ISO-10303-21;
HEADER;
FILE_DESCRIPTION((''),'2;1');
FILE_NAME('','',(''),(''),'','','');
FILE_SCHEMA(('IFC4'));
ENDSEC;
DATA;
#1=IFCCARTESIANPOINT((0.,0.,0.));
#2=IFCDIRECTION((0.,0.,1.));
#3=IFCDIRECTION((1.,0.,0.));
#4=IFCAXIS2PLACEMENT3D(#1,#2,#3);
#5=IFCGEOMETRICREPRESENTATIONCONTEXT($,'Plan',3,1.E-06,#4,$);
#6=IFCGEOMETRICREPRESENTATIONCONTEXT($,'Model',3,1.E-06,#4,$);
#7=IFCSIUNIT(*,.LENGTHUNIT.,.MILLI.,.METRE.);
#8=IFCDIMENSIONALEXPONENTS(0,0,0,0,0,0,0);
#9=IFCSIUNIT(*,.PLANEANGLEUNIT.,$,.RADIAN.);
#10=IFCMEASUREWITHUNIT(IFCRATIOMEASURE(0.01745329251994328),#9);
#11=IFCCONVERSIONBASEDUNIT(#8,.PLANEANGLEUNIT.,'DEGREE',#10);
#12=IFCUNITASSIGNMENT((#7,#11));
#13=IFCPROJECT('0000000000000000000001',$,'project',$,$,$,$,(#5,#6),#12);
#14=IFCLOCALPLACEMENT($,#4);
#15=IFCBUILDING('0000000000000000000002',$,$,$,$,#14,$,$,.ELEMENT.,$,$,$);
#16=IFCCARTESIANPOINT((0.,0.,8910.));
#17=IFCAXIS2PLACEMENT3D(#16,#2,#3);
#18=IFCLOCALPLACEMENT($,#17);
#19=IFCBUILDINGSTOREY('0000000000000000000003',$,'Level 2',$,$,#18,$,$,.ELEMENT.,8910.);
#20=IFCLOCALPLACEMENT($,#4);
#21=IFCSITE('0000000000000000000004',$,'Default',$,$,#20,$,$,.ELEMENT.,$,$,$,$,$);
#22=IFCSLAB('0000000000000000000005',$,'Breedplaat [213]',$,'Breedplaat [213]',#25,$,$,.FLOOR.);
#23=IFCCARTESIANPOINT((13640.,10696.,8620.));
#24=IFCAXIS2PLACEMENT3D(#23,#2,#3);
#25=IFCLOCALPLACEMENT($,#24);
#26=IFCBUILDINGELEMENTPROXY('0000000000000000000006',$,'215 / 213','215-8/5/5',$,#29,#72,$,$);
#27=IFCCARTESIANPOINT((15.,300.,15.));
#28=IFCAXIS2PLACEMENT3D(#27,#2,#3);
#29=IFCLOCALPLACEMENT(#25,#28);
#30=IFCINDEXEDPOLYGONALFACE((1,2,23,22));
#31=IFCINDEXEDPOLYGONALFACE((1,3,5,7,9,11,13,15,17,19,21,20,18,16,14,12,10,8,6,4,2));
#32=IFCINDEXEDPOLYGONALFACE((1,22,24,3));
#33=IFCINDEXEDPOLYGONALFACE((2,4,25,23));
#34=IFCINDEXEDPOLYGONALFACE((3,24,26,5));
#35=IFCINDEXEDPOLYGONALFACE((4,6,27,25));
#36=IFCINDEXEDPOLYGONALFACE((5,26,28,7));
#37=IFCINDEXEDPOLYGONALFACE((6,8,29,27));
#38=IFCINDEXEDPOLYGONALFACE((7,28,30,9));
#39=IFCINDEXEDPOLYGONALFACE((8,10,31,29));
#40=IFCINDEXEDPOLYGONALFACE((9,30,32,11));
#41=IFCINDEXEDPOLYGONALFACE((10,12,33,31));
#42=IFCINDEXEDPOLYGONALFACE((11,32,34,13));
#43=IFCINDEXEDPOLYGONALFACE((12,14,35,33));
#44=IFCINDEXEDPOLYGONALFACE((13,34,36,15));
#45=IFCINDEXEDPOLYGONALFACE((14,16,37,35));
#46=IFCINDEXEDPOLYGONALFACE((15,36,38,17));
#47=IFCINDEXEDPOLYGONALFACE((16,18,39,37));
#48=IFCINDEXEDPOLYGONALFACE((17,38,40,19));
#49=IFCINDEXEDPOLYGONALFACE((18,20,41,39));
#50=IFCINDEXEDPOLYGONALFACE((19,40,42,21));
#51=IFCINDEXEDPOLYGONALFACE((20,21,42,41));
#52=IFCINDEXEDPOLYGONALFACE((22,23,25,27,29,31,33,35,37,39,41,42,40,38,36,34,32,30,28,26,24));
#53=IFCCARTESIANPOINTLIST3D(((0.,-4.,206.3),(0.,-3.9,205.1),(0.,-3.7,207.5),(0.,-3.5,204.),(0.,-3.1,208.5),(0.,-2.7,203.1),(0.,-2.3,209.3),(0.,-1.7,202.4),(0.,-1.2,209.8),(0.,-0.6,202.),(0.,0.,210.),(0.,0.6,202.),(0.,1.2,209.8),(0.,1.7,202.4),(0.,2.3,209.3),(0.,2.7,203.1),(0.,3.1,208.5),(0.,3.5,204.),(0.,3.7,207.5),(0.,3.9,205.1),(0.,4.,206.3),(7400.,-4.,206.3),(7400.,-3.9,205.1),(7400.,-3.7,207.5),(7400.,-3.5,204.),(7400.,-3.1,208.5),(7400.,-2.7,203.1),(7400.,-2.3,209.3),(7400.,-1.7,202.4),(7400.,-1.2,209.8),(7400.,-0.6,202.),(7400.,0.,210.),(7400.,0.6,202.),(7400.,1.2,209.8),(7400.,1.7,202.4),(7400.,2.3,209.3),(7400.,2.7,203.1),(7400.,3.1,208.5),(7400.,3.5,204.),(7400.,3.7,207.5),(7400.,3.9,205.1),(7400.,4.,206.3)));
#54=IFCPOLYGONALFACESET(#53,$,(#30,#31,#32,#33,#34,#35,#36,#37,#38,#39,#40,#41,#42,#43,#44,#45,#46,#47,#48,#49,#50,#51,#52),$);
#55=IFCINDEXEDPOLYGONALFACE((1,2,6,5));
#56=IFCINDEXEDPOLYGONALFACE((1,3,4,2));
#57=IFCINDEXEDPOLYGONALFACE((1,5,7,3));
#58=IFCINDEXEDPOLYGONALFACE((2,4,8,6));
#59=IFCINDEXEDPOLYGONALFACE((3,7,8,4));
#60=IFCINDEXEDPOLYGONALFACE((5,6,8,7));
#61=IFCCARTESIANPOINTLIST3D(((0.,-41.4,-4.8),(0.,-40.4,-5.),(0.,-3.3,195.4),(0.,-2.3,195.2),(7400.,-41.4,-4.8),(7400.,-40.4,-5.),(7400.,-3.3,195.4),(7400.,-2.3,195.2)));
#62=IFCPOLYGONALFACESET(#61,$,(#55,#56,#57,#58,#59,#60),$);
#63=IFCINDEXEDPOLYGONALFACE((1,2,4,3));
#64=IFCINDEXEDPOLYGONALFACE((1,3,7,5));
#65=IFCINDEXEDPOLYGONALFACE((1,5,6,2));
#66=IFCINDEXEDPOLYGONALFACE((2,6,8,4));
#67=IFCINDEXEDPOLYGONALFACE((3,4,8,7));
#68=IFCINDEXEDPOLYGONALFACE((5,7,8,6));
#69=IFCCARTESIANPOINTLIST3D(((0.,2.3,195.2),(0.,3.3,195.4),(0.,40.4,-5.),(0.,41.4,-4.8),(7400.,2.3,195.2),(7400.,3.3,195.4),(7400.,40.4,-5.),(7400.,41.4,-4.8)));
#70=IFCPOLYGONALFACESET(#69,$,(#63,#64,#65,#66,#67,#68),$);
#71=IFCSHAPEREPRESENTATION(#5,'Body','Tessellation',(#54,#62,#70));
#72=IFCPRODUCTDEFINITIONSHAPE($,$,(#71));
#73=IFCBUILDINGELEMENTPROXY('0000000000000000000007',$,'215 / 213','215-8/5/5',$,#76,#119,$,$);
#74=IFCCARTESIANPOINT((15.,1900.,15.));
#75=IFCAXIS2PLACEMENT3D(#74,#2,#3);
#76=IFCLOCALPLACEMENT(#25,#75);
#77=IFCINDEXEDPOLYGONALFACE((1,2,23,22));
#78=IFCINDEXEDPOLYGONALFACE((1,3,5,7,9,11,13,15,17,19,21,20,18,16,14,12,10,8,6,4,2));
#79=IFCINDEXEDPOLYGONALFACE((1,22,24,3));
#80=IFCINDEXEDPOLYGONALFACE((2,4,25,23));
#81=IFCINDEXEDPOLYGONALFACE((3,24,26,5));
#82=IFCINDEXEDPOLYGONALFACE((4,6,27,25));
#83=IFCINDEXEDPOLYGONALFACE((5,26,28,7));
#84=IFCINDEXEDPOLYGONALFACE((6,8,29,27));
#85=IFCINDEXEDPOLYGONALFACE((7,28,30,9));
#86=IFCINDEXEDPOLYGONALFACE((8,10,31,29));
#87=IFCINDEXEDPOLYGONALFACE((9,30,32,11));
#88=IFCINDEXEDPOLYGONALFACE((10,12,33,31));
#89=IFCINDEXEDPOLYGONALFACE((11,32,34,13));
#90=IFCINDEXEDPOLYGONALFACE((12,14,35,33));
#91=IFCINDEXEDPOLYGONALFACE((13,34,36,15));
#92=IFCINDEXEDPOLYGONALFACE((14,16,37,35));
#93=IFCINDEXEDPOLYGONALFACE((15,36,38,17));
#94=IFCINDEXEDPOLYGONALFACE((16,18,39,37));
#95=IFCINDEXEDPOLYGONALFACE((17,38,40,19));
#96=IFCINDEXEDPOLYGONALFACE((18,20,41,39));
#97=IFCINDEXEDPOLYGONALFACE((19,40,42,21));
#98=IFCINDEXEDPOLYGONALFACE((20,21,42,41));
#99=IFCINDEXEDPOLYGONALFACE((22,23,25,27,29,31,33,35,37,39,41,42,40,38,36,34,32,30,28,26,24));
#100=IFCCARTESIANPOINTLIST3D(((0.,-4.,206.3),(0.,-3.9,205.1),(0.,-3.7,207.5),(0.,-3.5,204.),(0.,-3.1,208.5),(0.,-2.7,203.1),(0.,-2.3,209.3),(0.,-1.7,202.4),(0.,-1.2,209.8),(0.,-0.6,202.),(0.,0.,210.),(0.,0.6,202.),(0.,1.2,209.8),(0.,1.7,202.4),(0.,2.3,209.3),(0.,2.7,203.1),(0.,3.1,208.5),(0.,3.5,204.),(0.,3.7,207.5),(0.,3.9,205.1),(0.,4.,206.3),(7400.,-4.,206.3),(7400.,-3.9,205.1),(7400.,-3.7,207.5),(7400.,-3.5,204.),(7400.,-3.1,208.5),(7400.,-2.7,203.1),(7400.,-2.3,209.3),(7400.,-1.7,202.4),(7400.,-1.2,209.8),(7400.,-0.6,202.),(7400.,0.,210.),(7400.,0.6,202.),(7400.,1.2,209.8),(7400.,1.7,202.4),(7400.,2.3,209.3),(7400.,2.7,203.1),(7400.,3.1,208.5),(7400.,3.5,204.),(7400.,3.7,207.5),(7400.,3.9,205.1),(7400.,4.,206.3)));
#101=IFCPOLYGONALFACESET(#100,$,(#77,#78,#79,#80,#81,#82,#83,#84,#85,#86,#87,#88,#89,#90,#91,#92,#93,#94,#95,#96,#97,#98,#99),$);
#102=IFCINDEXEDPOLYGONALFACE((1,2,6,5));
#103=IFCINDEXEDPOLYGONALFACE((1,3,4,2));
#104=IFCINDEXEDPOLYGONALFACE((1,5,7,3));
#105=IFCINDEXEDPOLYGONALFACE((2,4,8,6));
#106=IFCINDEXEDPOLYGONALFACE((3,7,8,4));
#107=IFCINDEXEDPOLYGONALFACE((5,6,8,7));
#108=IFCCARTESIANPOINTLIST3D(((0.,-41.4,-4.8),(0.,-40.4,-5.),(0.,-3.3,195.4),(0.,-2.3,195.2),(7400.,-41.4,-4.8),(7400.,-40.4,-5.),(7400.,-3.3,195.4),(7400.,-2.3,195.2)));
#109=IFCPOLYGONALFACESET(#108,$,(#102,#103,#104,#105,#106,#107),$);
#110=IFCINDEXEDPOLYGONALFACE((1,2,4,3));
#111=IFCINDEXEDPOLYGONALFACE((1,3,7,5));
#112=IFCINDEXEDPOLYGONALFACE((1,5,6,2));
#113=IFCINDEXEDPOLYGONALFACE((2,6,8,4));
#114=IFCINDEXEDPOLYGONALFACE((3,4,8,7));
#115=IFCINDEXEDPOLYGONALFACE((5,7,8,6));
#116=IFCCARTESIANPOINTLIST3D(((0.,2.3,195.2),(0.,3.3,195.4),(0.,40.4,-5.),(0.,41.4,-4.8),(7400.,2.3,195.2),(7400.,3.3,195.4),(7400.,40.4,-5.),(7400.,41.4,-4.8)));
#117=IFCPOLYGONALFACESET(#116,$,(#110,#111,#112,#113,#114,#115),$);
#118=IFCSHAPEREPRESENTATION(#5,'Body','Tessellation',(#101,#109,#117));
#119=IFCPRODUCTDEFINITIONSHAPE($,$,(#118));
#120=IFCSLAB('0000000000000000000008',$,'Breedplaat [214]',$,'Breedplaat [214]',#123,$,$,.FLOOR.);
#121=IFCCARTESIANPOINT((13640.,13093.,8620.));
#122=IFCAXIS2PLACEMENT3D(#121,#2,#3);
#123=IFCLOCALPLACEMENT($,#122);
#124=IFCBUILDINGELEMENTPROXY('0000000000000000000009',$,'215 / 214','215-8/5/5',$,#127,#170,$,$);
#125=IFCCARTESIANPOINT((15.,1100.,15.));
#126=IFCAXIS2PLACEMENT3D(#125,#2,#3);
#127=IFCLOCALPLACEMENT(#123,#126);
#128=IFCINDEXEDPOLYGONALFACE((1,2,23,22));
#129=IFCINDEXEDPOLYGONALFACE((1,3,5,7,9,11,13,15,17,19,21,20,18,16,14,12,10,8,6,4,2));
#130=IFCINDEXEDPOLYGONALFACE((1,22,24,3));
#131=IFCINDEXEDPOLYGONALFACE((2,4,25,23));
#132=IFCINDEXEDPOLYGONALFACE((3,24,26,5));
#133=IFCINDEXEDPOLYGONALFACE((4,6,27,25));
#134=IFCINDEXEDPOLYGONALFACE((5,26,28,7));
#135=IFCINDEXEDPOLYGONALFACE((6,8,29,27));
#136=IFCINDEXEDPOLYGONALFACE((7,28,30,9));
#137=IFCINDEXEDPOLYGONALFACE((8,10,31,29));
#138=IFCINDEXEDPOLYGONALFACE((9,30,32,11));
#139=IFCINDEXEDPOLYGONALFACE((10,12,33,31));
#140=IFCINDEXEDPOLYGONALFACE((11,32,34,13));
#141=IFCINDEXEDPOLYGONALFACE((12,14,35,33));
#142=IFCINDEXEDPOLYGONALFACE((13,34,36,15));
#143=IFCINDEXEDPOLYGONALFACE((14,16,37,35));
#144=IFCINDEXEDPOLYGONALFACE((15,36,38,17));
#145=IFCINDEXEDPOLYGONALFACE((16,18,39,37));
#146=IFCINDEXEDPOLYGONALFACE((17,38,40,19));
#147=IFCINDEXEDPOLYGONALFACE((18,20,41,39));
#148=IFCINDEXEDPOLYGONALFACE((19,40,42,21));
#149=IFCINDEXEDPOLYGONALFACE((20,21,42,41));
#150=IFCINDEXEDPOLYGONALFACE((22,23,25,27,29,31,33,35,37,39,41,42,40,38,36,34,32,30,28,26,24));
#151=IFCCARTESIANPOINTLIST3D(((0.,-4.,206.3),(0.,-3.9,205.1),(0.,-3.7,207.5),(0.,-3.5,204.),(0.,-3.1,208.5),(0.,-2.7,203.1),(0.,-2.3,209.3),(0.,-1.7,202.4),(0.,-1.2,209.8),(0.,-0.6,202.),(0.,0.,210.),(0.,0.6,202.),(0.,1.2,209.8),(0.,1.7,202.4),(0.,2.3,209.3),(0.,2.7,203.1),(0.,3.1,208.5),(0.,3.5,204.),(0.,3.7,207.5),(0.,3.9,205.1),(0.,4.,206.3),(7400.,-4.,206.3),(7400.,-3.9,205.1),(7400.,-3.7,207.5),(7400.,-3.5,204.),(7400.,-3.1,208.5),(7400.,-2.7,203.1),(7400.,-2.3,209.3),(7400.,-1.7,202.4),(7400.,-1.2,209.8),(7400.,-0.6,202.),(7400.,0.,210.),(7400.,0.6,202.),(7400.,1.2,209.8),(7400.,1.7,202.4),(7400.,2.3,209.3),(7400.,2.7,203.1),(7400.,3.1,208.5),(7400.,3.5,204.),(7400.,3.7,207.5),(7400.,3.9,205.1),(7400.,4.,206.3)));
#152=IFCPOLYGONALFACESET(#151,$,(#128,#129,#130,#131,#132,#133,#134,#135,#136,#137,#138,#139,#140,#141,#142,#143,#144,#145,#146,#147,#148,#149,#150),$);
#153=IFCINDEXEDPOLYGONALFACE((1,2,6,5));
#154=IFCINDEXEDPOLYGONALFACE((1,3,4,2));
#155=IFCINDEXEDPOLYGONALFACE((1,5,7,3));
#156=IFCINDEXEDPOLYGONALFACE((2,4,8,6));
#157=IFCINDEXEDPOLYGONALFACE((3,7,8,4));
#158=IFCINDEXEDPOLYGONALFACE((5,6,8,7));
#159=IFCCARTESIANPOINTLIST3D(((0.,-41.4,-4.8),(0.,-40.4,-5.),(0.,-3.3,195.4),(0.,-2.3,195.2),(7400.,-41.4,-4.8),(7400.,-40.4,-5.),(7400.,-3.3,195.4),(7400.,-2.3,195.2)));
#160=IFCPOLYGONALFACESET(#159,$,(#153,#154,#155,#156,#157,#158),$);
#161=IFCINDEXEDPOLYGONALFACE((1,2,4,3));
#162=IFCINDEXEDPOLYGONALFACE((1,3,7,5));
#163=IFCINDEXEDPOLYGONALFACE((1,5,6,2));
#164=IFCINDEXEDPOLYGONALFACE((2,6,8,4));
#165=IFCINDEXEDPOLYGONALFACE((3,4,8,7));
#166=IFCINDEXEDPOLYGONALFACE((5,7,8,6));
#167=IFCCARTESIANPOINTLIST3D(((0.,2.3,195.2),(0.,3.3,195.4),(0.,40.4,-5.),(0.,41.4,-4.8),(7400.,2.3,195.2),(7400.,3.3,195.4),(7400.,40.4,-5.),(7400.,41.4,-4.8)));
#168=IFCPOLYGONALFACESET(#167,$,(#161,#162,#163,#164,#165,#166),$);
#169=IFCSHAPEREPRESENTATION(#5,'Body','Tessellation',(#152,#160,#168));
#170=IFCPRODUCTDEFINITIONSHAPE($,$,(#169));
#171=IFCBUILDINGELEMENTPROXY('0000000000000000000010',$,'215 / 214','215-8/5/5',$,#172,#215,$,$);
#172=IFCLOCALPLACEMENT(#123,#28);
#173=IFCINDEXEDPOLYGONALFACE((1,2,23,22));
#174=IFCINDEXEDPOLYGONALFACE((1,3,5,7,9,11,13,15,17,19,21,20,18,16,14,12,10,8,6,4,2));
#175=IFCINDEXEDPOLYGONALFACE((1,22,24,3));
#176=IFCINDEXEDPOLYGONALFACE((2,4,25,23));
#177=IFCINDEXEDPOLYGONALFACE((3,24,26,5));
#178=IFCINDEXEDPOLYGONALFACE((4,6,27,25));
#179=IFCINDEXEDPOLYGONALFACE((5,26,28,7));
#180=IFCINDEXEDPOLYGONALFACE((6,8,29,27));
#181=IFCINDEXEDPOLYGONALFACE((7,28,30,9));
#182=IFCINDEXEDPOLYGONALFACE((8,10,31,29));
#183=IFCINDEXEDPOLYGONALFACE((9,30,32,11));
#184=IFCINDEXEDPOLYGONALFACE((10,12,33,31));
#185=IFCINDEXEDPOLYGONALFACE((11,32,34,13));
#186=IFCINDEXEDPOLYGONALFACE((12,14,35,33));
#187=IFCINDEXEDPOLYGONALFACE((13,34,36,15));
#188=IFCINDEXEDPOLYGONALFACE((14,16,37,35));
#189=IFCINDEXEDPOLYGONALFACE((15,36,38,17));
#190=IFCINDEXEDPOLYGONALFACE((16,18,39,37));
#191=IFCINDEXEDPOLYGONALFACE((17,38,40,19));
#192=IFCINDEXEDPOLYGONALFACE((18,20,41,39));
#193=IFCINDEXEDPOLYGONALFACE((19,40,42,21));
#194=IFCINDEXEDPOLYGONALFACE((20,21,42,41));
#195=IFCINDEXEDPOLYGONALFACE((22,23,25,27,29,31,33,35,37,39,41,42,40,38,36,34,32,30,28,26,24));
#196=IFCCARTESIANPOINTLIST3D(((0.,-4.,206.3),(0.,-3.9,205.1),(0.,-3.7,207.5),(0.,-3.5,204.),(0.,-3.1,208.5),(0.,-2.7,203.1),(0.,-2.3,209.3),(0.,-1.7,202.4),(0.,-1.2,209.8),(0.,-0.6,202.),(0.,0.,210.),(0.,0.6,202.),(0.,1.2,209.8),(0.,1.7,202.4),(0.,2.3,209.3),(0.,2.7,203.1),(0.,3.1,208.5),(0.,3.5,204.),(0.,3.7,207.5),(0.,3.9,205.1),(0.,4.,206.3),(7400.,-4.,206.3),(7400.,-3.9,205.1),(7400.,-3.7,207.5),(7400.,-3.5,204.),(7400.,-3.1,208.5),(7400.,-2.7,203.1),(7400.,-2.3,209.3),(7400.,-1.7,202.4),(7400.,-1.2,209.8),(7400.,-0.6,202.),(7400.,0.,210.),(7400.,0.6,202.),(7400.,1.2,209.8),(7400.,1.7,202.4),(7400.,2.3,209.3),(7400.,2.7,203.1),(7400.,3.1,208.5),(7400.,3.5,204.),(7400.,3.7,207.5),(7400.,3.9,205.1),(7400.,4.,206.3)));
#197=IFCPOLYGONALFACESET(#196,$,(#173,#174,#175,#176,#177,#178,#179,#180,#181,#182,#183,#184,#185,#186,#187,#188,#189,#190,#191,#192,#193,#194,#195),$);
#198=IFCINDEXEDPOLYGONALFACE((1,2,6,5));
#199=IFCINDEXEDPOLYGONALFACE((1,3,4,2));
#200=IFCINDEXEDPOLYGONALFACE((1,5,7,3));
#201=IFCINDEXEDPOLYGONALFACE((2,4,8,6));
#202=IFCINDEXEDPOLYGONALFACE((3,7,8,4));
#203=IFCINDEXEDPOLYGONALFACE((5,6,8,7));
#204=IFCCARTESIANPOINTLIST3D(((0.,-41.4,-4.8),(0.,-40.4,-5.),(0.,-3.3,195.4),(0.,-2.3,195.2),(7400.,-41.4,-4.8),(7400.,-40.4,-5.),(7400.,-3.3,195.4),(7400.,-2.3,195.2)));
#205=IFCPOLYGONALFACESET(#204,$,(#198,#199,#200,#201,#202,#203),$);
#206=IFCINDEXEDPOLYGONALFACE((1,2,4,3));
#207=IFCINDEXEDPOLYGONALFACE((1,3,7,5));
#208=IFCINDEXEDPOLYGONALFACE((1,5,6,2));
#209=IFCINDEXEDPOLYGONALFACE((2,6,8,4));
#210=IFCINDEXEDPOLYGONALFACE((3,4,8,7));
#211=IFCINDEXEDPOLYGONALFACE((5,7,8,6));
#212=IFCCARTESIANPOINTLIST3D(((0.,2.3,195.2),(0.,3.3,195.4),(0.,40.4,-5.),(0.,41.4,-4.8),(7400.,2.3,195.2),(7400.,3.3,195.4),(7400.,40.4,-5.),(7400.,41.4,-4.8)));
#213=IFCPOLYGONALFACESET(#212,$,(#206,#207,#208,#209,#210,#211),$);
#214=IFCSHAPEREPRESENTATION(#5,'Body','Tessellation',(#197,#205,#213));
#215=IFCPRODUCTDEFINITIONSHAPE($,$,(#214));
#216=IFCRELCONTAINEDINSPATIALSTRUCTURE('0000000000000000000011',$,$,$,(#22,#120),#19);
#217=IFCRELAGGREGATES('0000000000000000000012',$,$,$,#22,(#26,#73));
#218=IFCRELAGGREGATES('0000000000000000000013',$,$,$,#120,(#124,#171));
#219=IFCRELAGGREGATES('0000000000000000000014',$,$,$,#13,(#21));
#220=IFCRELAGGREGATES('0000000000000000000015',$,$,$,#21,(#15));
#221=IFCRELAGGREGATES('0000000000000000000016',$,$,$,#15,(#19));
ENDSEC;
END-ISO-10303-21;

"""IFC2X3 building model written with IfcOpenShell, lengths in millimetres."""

from ifc_helpers import new_model, entity, si_unit, converted_unit, frame, origin_with_axes, origin_2d_with_axis, place, context, project, spatial, rectangle, circle, extrude, element, aggregate, save


model = new_model("IFC2X3")

# Units and contexts
plan_context = context("Plan", 3, precision=1e-06, world=origin_with_axes())
model_context = context("Model", 3, precision=1e-06, world=origin_with_axes())
ifc_project = project(units=[si_unit("LENGTHUNIT", "METRE", prefix="MILLI"), converted_unit("PLANEANGLEUNIT", "DEGREE", entity("IfcRatioMeasure", 0.01745329251994328), si_unit("PLANEANGLEUNIT", "RADIAN"), dimensions=[0, 0, 0, 0, 0, 0, 0])], contexts=[plan_context, model_context])

# Site, building, storey
site_placement = place(None, origin_with_axes())
site = spatial("IfcSite", under=ifc_project, at=site_placement, Name="Default", CompositionType="ELEMENT")
building_placement = place(None, origin_with_axes())
building = spatial("IfcBuilding", under=site, at=building_placement, CompositionType="ELEMENT")
storey_placement = place(None, frame((0.0, 0.0, 8910.0), z_axis=(0.0, 0.0, 1.0), x_axis=(1.0, 0.0, 0.0)))
storey = spatial("IfcBuildingStorey", under=building, at=storey_placement, Name="Level 2", CompositionType="ELEMENT", Elevation=8910.0)

# Slabs, building element proxies
slab_1_placement = place(None, frame((13640.0, 10696.0, 8620.0), z_axis=(0.0, 0.0, 1.0), x_axis=(1.0, 0.0, 0.0)))
slab_1 = element("IfcSlab", 1, at=slab_1_placement, inside=storey, Name="Breedplaat [213]", ObjectType="Breedplaat [213]", PredefinedType="FLOOR")
proxy_1_placement = place(slab_1_placement, frame((15.0, 300.0, 15.0), z_axis=(0.0, 0.0, 1.0), x_axis=(1.0, 0.0, 0.0)))
proxy_1 = element("IfcBuildingElementProxy", 2, at=proxy_1_placement, Name="215 / 213", Description="215-8/5/5", context=plan_context, shape_type="SweptSolid", body=[
    extrude(circle(Radius=4.0, at=origin_2d_with_axis()), frame((0.0, 0.0, 206.0), z_axis=(1.0, 0.0, 0.0), x_axis=(0.0, 0.0, 1.0)), (0.0, 0.0, 1.0), 7400.0),
    extrude(rectangle(XDim=203.8, YDim=1.0, at=origin_2d_with_axis()), frame((0.0, -21.9, 95.2), z_axis=(1.0, 0.0, 0.0), x_axis=(0.0, 0.187112, 0.982339)), (0.0, 0.0, 1.0), 7400.0),
    extrude(rectangle(XDim=203.8, YDim=1.0, at=origin_2d_with_axis()), frame((0.0, 21.9, 95.2), z_axis=(1.0, 0.0, 0.0), x_axis=(0.0, -0.187112, 0.982339)), (0.0, 0.0, 1.0), 7400.0),
])
proxy_2_placement = place(slab_1_placement, frame((15.0, 1900.0, 15.0), z_axis=(0.0, 0.0, 1.0), x_axis=(1.0, 0.0, 0.0)))
proxy_2 = element("IfcBuildingElementProxy", 3, at=proxy_2_placement, Name="215 / 213", Description="215-8/5/5", context=plan_context, shape_type="SweptSolid", body=[
    extrude(circle(Radius=4.0, at=origin_2d_with_axis()), frame((0.0, 0.0, 206.0), z_axis=(1.0, 0.0, 0.0), x_axis=(0.0, 0.0, 1.0)), (0.0, 0.0, 1.0), 7400.0),
    extrude(rectangle(XDim=203.8, YDim=1.0, at=origin_2d_with_axis()), frame((0.0, -21.9, 95.2), z_axis=(1.0, 0.0, 0.0), x_axis=(0.0, 0.187112, 0.982339)), (0.0, 0.0, 1.0), 7400.0),
    extrude(rectangle(XDim=203.8, YDim=1.0, at=origin_2d_with_axis()), frame((0.0, 21.9, 95.2), z_axis=(1.0, 0.0, 0.0), x_axis=(0.0, -0.187112, 0.982339)), (0.0, 0.0, 1.0), 7400.0),
])
aggregate(slab_1, [proxy_1, proxy_2])
slab_2_placement = place(None, frame((13640.0, 13093.0, 8620.0), z_axis=(0.0, 0.0, 1.0), x_axis=(1.0, 0.0, 0.0)))
slab_2 = element("IfcSlab", 4, at=slab_2_placement, inside=storey, Name="Breedplaat [214]", ObjectType="Breedplaat [214]", PredefinedType="FLOOR")
proxy_3_placement = place(slab_2_placement, frame((15.0, 1100.0, 15.0), z_axis=(0.0, 0.0, 1.0), x_axis=(1.0, 0.0, 0.0)))
proxy_3 = element("IfcBuildingElementProxy", 5, at=proxy_3_placement, Name="215 / 214", Description="215-8/5/5", context=plan_context, shape_type="SweptSolid", body=[
    extrude(circle(Radius=4.0, at=origin_2d_with_axis()), frame((0.0, 0.0, 206.0), z_axis=(1.0, 0.0, 0.0), x_axis=(0.0, 0.0, 1.0)), (0.0, 0.0, 1.0), 7400.0),
    extrude(rectangle(XDim=203.8, YDim=1.0, at=origin_2d_with_axis()), frame((0.0, -21.9, 95.2), z_axis=(1.0, 0.0, 0.0), x_axis=(0.0, 0.187112, 0.982339)), (0.0, 0.0, 1.0), 7400.0),
    extrude(rectangle(XDim=203.8, YDim=1.0, at=origin_2d_with_axis()), frame((0.0, 21.9, 95.2), z_axis=(1.0, 0.0, 0.0), x_axis=(0.0, -0.187112, 0.982339)), (0.0, 0.0, 1.0), 7400.0),
])
proxy_4_placement = place(slab_2_placement, frame((15.0, 300.0, 15.0), z_axis=(0.0, 0.0, 1.0), x_axis=(1.0, 0.0, 0.0)))
proxy_4 = element("IfcBuildingElementProxy", 6, at=proxy_4_placement, Name="215 / 214", Description="215-8/5/5", context=plan_context, shape_type="SweptSolid", body=[
    extrude(circle(Radius=4.0, at=origin_2d_with_axis()), frame((0.0, 0.0, 206.0), z_axis=(1.0, 0.0, 0.0), x_axis=(0.0, 0.0, 1.0)), (0.0, 0.0, 1.0), 7400.0),
    extrude(rectangle(XDim=203.8, YDim=1.0, at=origin_2d_with_axis()), frame((0.0, -21.9, 95.2), z_axis=(1.0, 0.0, 0.0), x_axis=(0.0, 0.187112, 0.982339)), (0.0, 0.0, 1.0), 7400.0),
    extrude(rectangle(XDim=203.8, YDim=1.0, at=origin_2d_with_axis()), frame((0.0, 21.9, 95.2), z_axis=(1.0, 0.0, 0.0), x_axis=(0.0, -0.187112, 0.982339)), (0.0, 0.0, 1.0), 7400.0),
])
aggregate(slab_2, [proxy_3, proxy_4])

save(model, "model.ifc")
